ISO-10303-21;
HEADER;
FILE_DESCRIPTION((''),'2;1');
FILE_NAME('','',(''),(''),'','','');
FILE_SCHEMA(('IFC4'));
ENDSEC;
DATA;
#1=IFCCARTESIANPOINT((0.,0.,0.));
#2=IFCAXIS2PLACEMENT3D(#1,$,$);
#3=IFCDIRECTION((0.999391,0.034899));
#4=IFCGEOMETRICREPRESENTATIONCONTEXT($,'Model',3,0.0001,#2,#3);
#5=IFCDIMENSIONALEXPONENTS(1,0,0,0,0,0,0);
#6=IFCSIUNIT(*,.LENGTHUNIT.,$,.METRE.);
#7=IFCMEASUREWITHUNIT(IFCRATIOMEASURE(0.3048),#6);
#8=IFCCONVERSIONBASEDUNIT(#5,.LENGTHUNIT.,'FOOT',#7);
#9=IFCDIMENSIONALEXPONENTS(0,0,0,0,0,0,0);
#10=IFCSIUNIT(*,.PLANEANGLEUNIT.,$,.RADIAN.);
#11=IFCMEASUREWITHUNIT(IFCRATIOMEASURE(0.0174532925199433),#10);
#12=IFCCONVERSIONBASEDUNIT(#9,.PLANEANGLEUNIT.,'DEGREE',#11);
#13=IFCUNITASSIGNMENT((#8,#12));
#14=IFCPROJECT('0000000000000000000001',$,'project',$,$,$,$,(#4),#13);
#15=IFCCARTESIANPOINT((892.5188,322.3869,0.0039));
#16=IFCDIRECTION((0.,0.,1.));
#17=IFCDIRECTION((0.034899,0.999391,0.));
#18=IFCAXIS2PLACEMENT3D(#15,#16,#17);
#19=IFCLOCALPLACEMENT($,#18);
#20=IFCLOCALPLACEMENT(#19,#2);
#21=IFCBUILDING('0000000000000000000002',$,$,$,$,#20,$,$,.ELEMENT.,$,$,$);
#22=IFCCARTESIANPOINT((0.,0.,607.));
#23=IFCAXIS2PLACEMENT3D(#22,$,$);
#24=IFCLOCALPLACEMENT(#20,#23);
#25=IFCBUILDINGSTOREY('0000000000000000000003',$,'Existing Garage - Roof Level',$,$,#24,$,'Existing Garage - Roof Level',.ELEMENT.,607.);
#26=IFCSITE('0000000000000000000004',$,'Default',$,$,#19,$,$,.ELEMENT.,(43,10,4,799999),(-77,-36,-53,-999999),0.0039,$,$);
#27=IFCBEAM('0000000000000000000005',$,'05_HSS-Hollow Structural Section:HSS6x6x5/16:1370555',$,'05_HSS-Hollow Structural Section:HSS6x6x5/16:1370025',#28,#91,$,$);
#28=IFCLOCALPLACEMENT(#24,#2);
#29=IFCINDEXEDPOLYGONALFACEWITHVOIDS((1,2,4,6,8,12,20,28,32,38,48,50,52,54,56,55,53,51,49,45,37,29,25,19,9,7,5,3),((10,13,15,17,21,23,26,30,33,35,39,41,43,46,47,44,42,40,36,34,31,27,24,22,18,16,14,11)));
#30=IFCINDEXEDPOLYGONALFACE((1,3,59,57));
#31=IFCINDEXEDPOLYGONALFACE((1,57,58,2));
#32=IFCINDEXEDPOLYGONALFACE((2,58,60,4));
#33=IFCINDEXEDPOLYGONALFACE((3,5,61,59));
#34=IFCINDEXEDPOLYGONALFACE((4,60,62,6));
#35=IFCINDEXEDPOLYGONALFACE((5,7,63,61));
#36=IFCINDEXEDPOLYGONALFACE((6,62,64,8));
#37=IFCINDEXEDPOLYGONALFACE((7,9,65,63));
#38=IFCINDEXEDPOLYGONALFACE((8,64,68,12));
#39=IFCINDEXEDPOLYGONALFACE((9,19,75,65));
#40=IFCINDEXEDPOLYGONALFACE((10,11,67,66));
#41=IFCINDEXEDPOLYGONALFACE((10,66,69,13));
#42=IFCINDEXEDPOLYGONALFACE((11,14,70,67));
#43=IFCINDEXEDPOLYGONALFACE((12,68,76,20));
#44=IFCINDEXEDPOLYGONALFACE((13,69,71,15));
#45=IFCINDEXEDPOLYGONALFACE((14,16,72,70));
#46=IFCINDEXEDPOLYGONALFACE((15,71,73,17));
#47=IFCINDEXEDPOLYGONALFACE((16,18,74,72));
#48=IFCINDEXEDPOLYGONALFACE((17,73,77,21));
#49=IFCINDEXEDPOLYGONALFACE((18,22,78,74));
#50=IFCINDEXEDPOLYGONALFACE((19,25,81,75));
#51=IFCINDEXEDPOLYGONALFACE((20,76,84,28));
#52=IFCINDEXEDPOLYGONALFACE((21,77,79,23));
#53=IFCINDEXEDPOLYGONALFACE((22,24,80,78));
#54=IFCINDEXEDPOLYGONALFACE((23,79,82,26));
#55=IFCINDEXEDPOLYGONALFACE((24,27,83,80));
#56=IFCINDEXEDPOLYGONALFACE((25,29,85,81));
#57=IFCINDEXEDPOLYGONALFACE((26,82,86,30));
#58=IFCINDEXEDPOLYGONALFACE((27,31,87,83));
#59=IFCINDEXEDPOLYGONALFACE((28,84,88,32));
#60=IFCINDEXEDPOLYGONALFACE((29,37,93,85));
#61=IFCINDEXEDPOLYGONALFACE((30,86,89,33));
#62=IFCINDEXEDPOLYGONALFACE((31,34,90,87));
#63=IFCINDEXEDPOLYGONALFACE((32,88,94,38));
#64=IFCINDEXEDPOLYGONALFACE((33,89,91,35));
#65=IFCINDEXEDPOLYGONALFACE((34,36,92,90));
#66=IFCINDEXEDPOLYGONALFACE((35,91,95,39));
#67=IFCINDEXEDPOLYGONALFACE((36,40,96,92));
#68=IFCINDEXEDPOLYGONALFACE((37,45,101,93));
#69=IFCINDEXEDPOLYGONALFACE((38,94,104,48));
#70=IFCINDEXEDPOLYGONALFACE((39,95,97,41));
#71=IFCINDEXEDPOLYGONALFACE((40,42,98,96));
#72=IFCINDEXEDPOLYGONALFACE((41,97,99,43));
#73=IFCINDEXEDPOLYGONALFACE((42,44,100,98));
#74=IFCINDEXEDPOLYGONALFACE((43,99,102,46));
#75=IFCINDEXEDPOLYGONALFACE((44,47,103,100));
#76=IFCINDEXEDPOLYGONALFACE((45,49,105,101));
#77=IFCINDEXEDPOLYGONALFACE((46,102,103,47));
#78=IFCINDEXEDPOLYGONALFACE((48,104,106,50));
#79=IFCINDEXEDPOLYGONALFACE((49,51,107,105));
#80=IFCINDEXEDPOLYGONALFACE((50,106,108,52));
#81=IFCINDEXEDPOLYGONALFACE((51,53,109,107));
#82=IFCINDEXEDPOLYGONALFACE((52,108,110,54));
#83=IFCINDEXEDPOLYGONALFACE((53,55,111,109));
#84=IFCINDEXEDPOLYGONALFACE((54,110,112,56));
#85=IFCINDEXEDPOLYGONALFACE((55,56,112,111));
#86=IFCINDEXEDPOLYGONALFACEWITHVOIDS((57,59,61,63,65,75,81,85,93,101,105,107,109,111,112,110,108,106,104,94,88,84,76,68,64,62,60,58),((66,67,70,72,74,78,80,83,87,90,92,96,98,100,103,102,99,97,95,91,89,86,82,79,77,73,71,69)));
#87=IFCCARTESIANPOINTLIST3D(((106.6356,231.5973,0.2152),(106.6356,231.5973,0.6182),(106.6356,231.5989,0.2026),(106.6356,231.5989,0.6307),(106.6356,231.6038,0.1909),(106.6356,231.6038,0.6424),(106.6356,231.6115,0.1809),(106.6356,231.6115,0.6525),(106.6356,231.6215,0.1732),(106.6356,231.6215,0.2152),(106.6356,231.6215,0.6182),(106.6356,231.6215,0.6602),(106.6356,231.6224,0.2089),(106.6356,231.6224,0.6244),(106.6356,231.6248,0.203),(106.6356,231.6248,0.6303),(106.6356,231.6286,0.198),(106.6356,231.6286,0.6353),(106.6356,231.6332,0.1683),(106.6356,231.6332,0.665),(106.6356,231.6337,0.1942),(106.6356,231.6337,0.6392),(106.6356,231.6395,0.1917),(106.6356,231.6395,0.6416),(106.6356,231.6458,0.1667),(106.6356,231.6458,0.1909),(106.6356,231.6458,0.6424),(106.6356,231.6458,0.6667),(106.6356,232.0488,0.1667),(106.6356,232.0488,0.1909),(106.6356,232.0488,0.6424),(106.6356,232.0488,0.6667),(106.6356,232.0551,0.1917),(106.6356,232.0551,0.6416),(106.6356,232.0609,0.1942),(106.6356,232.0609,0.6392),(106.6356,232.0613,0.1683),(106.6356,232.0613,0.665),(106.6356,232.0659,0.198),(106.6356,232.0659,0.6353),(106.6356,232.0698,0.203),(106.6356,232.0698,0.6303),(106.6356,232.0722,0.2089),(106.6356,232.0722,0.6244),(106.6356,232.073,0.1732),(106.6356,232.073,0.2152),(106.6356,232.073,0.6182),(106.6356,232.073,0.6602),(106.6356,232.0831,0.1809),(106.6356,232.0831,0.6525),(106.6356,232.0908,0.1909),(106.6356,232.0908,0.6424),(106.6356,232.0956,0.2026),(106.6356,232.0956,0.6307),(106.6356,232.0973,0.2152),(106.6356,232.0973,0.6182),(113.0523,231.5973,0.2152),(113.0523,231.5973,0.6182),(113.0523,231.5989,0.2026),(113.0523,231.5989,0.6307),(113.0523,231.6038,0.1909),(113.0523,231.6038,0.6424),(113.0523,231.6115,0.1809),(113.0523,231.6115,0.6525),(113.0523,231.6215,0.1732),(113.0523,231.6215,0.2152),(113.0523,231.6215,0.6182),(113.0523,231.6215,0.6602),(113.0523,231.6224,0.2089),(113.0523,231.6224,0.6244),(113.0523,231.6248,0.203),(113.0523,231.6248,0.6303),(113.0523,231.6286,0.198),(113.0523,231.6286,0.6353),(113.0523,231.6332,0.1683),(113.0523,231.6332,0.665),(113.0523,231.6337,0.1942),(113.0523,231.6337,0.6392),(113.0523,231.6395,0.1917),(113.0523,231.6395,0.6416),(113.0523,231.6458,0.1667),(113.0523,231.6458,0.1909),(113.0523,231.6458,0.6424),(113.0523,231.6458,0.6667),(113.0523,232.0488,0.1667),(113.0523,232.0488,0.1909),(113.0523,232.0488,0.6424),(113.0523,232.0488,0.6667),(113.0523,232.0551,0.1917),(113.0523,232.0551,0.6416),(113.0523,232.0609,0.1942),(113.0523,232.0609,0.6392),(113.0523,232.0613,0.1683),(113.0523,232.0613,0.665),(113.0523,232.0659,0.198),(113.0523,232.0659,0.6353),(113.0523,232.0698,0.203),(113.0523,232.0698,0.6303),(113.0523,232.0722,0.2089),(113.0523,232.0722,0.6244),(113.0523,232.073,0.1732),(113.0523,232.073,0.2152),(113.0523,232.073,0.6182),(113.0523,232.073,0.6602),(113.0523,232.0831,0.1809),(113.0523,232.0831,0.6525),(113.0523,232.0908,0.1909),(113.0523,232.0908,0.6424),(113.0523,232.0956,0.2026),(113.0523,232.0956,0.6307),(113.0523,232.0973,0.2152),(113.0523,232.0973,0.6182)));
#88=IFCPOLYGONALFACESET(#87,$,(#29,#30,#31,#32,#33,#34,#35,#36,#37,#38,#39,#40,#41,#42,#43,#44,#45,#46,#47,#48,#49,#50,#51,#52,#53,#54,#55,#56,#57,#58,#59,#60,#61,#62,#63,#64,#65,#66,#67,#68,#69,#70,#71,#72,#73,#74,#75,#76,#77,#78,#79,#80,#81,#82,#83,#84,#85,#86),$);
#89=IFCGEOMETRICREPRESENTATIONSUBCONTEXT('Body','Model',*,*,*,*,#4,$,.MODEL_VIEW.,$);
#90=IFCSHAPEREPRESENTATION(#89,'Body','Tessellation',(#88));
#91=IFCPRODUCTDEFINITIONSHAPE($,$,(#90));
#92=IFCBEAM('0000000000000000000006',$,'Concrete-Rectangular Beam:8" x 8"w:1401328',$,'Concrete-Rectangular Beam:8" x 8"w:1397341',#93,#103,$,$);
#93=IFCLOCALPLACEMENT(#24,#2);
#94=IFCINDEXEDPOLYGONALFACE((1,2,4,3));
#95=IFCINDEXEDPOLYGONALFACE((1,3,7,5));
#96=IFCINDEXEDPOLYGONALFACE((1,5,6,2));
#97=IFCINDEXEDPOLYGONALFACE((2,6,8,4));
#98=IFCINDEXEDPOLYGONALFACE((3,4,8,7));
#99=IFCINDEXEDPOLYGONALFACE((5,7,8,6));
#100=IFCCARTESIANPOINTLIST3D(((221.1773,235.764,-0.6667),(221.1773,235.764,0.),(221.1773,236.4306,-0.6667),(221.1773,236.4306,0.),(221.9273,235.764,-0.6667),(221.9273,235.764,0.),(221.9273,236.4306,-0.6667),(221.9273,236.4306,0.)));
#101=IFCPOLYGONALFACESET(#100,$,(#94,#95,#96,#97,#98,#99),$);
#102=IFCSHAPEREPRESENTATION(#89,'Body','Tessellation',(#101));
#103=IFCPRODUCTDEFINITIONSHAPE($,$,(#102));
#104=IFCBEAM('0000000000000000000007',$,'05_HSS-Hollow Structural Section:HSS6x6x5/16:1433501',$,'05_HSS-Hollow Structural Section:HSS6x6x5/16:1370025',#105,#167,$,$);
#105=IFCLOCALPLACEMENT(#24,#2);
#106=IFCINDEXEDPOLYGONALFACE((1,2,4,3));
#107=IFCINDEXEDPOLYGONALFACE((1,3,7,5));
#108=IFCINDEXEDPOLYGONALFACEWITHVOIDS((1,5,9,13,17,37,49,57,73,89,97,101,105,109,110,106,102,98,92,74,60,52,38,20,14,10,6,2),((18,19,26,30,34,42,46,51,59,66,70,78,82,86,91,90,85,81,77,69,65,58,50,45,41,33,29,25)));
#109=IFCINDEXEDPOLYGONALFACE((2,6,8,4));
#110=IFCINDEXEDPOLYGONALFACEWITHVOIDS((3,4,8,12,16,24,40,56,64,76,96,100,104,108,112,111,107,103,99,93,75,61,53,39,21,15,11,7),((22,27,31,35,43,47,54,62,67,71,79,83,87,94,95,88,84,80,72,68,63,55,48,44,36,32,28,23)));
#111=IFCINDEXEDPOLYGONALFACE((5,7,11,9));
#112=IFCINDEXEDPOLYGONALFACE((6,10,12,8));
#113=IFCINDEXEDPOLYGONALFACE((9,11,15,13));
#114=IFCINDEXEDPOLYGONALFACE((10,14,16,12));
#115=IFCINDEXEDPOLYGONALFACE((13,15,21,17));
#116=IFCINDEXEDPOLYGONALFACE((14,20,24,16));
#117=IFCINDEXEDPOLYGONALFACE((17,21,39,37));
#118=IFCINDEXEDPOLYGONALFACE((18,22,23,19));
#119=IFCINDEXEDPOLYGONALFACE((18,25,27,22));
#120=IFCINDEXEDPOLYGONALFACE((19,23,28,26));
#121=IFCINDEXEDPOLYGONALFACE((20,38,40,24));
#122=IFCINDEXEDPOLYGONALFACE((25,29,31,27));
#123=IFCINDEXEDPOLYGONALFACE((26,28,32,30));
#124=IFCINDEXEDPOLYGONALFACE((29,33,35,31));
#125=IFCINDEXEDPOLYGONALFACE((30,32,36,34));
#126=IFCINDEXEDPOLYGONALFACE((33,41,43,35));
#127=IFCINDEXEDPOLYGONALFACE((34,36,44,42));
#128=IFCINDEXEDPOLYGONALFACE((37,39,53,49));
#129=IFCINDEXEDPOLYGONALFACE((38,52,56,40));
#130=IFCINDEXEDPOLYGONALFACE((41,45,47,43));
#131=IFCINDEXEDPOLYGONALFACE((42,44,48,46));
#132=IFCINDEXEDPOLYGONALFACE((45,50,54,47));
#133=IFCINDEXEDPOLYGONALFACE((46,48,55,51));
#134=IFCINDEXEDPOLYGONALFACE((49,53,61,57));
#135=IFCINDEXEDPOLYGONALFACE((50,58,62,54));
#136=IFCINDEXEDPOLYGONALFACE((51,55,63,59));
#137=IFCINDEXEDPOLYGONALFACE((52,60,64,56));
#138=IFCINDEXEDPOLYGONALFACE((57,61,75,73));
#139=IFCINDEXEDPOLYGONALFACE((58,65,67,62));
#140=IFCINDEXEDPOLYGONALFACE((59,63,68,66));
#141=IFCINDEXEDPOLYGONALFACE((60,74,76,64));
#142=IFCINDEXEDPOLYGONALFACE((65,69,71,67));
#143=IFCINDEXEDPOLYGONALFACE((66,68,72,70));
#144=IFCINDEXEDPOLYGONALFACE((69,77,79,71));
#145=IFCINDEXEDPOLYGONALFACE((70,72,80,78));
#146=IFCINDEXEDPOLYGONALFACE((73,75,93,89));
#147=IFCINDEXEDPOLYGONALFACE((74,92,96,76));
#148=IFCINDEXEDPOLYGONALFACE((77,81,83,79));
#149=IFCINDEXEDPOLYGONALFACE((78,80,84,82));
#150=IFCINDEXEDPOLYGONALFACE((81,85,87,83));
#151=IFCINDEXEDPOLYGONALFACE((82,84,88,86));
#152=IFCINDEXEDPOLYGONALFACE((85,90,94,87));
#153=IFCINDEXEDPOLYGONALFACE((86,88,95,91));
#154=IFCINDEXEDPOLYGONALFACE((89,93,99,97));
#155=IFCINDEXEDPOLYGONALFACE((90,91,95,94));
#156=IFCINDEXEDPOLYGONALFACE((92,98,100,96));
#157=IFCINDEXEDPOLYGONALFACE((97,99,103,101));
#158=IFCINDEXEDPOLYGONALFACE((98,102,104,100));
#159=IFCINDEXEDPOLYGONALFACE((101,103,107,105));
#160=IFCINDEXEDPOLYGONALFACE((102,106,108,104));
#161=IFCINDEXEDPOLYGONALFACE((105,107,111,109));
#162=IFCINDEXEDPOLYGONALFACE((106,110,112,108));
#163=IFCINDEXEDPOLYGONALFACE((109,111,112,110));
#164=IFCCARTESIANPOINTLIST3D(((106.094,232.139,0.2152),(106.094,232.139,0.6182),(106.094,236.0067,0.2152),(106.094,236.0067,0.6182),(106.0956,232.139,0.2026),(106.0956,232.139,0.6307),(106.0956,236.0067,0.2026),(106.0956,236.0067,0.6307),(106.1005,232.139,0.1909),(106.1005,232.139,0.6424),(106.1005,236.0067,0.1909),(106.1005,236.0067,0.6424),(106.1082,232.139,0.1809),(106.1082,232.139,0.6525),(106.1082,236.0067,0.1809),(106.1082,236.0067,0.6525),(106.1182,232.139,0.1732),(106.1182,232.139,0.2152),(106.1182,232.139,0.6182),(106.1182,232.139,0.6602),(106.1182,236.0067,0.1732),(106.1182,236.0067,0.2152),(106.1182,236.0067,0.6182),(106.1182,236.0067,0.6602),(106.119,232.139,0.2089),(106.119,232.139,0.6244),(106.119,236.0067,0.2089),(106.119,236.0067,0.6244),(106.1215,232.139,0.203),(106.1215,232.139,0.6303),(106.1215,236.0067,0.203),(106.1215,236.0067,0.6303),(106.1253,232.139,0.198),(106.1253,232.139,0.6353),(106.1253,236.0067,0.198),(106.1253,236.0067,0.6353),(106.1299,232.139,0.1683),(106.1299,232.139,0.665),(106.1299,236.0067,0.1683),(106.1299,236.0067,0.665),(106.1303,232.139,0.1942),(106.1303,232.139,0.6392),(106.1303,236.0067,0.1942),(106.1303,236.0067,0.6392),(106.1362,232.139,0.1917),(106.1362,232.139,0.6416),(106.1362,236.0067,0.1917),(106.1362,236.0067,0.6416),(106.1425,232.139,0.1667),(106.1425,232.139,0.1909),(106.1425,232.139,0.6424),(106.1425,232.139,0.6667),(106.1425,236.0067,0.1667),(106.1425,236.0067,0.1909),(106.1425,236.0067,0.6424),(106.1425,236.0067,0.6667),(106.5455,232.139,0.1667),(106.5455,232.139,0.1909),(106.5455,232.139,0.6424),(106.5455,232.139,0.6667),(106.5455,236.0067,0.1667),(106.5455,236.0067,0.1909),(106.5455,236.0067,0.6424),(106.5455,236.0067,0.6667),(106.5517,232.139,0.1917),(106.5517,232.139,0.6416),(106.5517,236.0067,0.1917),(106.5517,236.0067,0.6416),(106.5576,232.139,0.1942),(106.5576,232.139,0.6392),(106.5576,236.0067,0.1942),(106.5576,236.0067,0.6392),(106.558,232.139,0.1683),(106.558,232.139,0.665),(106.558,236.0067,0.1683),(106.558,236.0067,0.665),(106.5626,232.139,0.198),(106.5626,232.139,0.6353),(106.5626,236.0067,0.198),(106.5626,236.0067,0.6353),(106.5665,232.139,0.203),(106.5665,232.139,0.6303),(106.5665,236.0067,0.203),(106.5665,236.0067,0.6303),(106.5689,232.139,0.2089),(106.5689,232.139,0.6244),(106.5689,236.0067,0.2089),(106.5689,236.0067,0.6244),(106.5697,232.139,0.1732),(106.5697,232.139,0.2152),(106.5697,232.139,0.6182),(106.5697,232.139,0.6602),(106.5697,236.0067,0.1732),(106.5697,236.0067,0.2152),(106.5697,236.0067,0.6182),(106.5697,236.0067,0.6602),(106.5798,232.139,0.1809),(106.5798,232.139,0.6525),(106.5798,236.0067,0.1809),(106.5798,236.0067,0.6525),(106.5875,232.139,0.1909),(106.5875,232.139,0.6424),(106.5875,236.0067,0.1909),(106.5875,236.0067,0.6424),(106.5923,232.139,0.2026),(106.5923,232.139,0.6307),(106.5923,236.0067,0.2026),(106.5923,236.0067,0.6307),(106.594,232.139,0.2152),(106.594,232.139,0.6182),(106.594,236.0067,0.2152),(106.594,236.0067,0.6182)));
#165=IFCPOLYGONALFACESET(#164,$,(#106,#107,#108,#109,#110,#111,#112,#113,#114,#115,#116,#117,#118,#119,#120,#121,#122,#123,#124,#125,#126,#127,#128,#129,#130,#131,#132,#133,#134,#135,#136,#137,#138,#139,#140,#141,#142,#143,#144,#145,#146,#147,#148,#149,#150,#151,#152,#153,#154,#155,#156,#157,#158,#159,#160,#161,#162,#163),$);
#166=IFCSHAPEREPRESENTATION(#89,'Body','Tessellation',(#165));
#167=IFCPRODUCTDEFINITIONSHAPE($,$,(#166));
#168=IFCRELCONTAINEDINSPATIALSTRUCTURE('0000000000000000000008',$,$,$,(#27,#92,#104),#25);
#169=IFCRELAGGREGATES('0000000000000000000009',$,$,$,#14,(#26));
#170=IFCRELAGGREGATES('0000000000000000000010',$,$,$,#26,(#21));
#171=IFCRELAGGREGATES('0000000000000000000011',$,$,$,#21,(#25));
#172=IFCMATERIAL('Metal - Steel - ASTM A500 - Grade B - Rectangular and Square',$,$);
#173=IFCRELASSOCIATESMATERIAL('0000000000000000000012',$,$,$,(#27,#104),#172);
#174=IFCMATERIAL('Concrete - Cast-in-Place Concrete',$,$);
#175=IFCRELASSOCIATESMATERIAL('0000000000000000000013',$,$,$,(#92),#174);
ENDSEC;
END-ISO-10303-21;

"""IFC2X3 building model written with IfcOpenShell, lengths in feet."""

from ifc_helpers import new_model, entity, si_unit, converted_unit, direction, frame, frame_2d, origin, origin_2d_with_axis, place, context, subcontext, project, spatial, polyline, circle_curve, parameter, trimmed, segment, composite_curve, rectangle, outline, extrude, material, element, save


model = new_model("IFC2X3")

# Units and contexts
model_context = context("Model", 3, precision=0.0001, world=origin(), true_north=direction((0.999391, 0.034899)))
body_context = subcontext(model_context, "Body", "Model", "MODEL_VIEW")
ifc_project = project(units=[converted_unit("LENGTHUNIT", "FOOT", entity("IfcRatioMeasure", 0.3048), si_unit("LENGTHUNIT", "METRE"), dimensions=[1, 0, 0, 0, 0, 0, 0]), converted_unit("PLANEANGLEUNIT", "DEGREE", entity("IfcRatioMeasure", 0.0174532925199433), si_unit("PLANEANGLEUNIT", "RADIAN"), dimensions=[0, 0, 0, 0, 0, 0, 0])], contexts=[model_context])

# Site, building, storey
site_placement = place(None, frame((892.5188, 322.3869, 0.0039), z_axis=(0.0, 0.0, 1.0), x_axis=(0.034899, 0.999391, 0.0)))
site = spatial("IfcSite", under=ifc_project, at=site_placement, Name="Default", CompositionType="ELEMENT", RefLatitude=(43, 10, 4, 799999), RefLongitude=(-77, -36, -53, -999999), RefElevation=0.0039)
building_placement = place(site_placement, origin())
building = spatial("IfcBuilding", under=site, at=building_placement, CompositionType="ELEMENT")
storey_placement = place(building_placement, frame((0.0, 0.0, 607.0)))
storey = spatial("IfcBuildingStorey", under=building, at=storey_placement, Name="Existing Garage - Roof Level", LongName="Existing Garage - Roof Level", CompositionType="ELEMENT", Elevation=607.0)

# Beams
ifc_material_1 = material(Name="Metal - Steel - ASTM A500 - Grade B - Rectangular and Square")
beam_1_placement = place(storey_placement, frame((113.344, 231.8473, 0.6667), z_axis=(0.0, 0.0, 1.0), x_axis=(-1.0, 0.0, 0.0)))
element("IfcBeam", 1, at=beam_1_placement, inside=storey, material=ifc_material_1, Name="05_HSS-Hollow Structural Section:HSS6x6x5/16:1370555", ObjectType="05_HSS-Hollow Structural Section:HSS6x6x5/16:1370025", context=body_context, shape_type="SweptSolid", body=[
    extrude(outline(composite_curve([segment(trimmed(circle_curve(frame_2d((-0.2015, -0.2015), x_axis=(1.0, 0.0)), 0.0485), [parameter(180.0)], [parameter(270.0)], True, "PARAMETER"), True, "CONTINUOUS"), segment(polyline([(-0.2015, -0.25), (0.2015, -0.25)]), True, "CONTINUOUS"), segment(trimmed(circle_curve(frame_2d((0.2015, -0.2015), x_axis=(1.0, 0.0)), 0.0485), [parameter(270.0)], [parameter(0.0)], True, "PARAMETER"), True, "CONTINUOUS"), segment(polyline([(0.25, -0.2015), (0.25, 0.2015)]), True, "CONTINUOUS"), segment(trimmed(circle_curve(frame_2d((0.2015, 0.2015), x_axis=(1.0, 0.0)), 0.0485), [parameter(360.0)], [parameter(90.0)], True, "PARAMETER"), True, "CONTINUOUS"), segment(polyline([(0.2015, 0.25), (-0.2015, 0.25)]), True, "CONTINUOUS"), segment(trimmed(circle_curve(frame_2d((-0.2015, 0.2015), x_axis=(1.0, 0.0)), 0.0485), [parameter(90.0)], [parameter(180.0)], True, "PARAMETER"), True, "CONTINUOUS"), segment(polyline([(-0.25, 0.2015), (-0.25, -0.2015)]), True, "CONTINUOUS")], self_intersect=False), holes=[composite_curve([segment(polyline([(0.2015, -0.2257), (-0.2015, -0.2257)]), True, "CONTINUOUS"), segment(trimmed(circle_curve(frame_2d((-0.2015, -0.2015), x_axis=(1.0, 0.0)), 0.0243), [parameter(180.0)], [parameter(270.0)], True, "PARAMETER"), False, "CONTINUOUS"), segment(polyline([(-0.2258, -0.2015), (-0.2258, 0.2015)]), True, "CONTINUOUS"), segment(trimmed(circle_curve(frame_2d((-0.2015, 0.2015), x_axis=(1.0, 0.0)), 0.0243), [parameter(90.0)], [parameter(180.0)], True, "PARAMETER"), False, "CONTINUOUS"), segment(polyline([(-0.2015, 0.2258), (0.2015, 0.2258)]), True, "CONTINUOUS"), segment(trimmed(circle_curve(frame_2d((0.2015, 0.2015), x_axis=(1.0, 0.0)), 0.0243), [parameter(0.0)], [parameter(90.0)], True, "PARAMETER"), False, "CONTINUOUS"), segment(polyline([(0.2257, 0.2015), (0.2257, -0.2015)]), True, "CONTINUOUS"), segment(trimmed(circle_curve(frame_2d((0.2015, -0.2015), x_axis=(1.0, 0.0)), 0.0243), [parameter(270.0)], [parameter(0.0)], True, "PARAMETER"), False, "CONTINUOUS")], self_intersect=False)]), frame((0.2917, 0.0, -0.25), z_axis=(1.0, 0.0, 0.0), x_axis=(0.0, -1.0, 0.0)), (0.0, 0.0, 1.0), 6.4167),
])
ifc_material_2 = material(Name="Concrete - Cast-in-Place Concrete")
beam_2_placement = place(storey_placement, frame((221.1773, 236.0973, 0.0)))
element("IfcBeam", 2, at=beam_2_placement, inside=storey, material=ifc_material_2, Name="Concrete-Rectangular Beam:8\" x 8\"w:1401328", ObjectType="Concrete-Rectangular Beam:8\" x 8\"w:1397341", context=body_context, shape_type="SweptSolid", body=[
    extrude(rectangle(XDim=0.6667, YDim=0.6667, at=origin_2d_with_axis()), frame((0.0, 0.0, -0.3333), z_axis=(1.0, 0.0, 0.0), x_axis=(0.0, 0.0, -1.0)), (0.0, 0.0, 1.0), 0.75),
])
beam_3_placement = place(storey_placement, frame((106.344, 231.8473, 0.6667), z_axis=(0.0, 0.0, 1.0), x_axis=(0.0, 1.0, 0.0)))
element("IfcBeam", 3, at=beam_3_placement, inside=storey, material=ifc_material_1, Name="05_HSS-Hollow Structural Section:HSS6x6x5/16:1433501", ObjectType="05_HSS-Hollow Structural Section:HSS6x6x5/16:1370025", context=body_context, shape_type="SweptSolid", body=[
    extrude(outline(composite_curve([segment(trimmed(circle_curve(frame_2d((-0.2015, -0.2015), x_axis=(1.0, 0.0)), 0.0485), [parameter(180.0)], [parameter(270.0)], True, "PARAMETER"), True, "CONTINUOUS"), segment(polyline([(-0.2015, -0.25), (0.2015, -0.25)]), True, "CONTINUOUS"), segment(trimmed(circle_curve(frame_2d((0.2015, -0.2015), x_axis=(1.0, 0.0)), 0.0485), [parameter(270.0)], [parameter(0.0)], True, "PARAMETER"), True, "CONTINUOUS"), segment(polyline([(0.25, -0.2015), (0.25, 0.2015)]), True, "CONTINUOUS"), segment(trimmed(circle_curve(frame_2d((0.2015, 0.2015), x_axis=(1.0, 0.0)), 0.0485), [parameter(360.0)], [parameter(90.0)], True, "PARAMETER"), True, "CONTINUOUS"), segment(polyline([(0.2015, 0.25), (-0.2015, 0.25)]), True, "CONTINUOUS"), segment(trimmed(circle_curve(frame_2d((-0.2015, 0.2015), x_axis=(1.0, 0.0)), 0.0485), [parameter(90.0)], [parameter(180.0)], True, "PARAMETER"), True, "CONTINUOUS"), segment(polyline([(-0.25, 0.2015), (-0.25, -0.2015)]), True, "CONTINUOUS")], self_intersect=False), holes=[composite_curve([segment(polyline([(0.2015, -0.2257), (-0.2015, -0.2257)]), True, "CONTINUOUS"), segment(trimmed(circle_curve(frame_2d((-0.2015, -0.2015), x_axis=(1.0, 0.0)), 0.0243), [parameter(180.0)], [parameter(270.0)], True, "PARAMETER"), False, "CONTINUOUS"), segment(polyline([(-0.2258, -0.2015), (-0.2258, 0.2015)]), True, "CONTINUOUS"), segment(trimmed(circle_curve(frame_2d((-0.2015, 0.2015), x_axis=(1.0, 0.0)), 0.0243), [parameter(90.0)], [parameter(180.0)], True, "PARAMETER"), False, "CONTINUOUS"), segment(polyline([(-0.2015, 0.2258), (0.2015, 0.2258)]), True, "CONTINUOUS"), segment(trimmed(circle_curve(frame_2d((0.2015, 0.2015), x_axis=(1.0, 0.0)), 0.0243), [parameter(0.0)], [parameter(90.0)], True, "PARAMETER"), False, "CONTINUOUS"), segment(polyline([(0.2257, 0.2015), (0.2257, -0.2015)]), True, "CONTINUOUS"), segment(trimmed(circle_curve(frame_2d((0.2015, -0.2015), x_axis=(1.0, 0.0)), 0.0243), [parameter(270.0)], [parameter(0.0)], True, "PARAMETER"), False, "CONTINUOUS")], self_intersect=False)]), frame((0.2917, 0.0, -0.25), z_axis=(1.0, 0.0, 0.0), x_axis=(0.0, -1.0, 0.0)), (0.0, 0.0, 1.0), 3.8677),
])

save(model, "model.ifc")
